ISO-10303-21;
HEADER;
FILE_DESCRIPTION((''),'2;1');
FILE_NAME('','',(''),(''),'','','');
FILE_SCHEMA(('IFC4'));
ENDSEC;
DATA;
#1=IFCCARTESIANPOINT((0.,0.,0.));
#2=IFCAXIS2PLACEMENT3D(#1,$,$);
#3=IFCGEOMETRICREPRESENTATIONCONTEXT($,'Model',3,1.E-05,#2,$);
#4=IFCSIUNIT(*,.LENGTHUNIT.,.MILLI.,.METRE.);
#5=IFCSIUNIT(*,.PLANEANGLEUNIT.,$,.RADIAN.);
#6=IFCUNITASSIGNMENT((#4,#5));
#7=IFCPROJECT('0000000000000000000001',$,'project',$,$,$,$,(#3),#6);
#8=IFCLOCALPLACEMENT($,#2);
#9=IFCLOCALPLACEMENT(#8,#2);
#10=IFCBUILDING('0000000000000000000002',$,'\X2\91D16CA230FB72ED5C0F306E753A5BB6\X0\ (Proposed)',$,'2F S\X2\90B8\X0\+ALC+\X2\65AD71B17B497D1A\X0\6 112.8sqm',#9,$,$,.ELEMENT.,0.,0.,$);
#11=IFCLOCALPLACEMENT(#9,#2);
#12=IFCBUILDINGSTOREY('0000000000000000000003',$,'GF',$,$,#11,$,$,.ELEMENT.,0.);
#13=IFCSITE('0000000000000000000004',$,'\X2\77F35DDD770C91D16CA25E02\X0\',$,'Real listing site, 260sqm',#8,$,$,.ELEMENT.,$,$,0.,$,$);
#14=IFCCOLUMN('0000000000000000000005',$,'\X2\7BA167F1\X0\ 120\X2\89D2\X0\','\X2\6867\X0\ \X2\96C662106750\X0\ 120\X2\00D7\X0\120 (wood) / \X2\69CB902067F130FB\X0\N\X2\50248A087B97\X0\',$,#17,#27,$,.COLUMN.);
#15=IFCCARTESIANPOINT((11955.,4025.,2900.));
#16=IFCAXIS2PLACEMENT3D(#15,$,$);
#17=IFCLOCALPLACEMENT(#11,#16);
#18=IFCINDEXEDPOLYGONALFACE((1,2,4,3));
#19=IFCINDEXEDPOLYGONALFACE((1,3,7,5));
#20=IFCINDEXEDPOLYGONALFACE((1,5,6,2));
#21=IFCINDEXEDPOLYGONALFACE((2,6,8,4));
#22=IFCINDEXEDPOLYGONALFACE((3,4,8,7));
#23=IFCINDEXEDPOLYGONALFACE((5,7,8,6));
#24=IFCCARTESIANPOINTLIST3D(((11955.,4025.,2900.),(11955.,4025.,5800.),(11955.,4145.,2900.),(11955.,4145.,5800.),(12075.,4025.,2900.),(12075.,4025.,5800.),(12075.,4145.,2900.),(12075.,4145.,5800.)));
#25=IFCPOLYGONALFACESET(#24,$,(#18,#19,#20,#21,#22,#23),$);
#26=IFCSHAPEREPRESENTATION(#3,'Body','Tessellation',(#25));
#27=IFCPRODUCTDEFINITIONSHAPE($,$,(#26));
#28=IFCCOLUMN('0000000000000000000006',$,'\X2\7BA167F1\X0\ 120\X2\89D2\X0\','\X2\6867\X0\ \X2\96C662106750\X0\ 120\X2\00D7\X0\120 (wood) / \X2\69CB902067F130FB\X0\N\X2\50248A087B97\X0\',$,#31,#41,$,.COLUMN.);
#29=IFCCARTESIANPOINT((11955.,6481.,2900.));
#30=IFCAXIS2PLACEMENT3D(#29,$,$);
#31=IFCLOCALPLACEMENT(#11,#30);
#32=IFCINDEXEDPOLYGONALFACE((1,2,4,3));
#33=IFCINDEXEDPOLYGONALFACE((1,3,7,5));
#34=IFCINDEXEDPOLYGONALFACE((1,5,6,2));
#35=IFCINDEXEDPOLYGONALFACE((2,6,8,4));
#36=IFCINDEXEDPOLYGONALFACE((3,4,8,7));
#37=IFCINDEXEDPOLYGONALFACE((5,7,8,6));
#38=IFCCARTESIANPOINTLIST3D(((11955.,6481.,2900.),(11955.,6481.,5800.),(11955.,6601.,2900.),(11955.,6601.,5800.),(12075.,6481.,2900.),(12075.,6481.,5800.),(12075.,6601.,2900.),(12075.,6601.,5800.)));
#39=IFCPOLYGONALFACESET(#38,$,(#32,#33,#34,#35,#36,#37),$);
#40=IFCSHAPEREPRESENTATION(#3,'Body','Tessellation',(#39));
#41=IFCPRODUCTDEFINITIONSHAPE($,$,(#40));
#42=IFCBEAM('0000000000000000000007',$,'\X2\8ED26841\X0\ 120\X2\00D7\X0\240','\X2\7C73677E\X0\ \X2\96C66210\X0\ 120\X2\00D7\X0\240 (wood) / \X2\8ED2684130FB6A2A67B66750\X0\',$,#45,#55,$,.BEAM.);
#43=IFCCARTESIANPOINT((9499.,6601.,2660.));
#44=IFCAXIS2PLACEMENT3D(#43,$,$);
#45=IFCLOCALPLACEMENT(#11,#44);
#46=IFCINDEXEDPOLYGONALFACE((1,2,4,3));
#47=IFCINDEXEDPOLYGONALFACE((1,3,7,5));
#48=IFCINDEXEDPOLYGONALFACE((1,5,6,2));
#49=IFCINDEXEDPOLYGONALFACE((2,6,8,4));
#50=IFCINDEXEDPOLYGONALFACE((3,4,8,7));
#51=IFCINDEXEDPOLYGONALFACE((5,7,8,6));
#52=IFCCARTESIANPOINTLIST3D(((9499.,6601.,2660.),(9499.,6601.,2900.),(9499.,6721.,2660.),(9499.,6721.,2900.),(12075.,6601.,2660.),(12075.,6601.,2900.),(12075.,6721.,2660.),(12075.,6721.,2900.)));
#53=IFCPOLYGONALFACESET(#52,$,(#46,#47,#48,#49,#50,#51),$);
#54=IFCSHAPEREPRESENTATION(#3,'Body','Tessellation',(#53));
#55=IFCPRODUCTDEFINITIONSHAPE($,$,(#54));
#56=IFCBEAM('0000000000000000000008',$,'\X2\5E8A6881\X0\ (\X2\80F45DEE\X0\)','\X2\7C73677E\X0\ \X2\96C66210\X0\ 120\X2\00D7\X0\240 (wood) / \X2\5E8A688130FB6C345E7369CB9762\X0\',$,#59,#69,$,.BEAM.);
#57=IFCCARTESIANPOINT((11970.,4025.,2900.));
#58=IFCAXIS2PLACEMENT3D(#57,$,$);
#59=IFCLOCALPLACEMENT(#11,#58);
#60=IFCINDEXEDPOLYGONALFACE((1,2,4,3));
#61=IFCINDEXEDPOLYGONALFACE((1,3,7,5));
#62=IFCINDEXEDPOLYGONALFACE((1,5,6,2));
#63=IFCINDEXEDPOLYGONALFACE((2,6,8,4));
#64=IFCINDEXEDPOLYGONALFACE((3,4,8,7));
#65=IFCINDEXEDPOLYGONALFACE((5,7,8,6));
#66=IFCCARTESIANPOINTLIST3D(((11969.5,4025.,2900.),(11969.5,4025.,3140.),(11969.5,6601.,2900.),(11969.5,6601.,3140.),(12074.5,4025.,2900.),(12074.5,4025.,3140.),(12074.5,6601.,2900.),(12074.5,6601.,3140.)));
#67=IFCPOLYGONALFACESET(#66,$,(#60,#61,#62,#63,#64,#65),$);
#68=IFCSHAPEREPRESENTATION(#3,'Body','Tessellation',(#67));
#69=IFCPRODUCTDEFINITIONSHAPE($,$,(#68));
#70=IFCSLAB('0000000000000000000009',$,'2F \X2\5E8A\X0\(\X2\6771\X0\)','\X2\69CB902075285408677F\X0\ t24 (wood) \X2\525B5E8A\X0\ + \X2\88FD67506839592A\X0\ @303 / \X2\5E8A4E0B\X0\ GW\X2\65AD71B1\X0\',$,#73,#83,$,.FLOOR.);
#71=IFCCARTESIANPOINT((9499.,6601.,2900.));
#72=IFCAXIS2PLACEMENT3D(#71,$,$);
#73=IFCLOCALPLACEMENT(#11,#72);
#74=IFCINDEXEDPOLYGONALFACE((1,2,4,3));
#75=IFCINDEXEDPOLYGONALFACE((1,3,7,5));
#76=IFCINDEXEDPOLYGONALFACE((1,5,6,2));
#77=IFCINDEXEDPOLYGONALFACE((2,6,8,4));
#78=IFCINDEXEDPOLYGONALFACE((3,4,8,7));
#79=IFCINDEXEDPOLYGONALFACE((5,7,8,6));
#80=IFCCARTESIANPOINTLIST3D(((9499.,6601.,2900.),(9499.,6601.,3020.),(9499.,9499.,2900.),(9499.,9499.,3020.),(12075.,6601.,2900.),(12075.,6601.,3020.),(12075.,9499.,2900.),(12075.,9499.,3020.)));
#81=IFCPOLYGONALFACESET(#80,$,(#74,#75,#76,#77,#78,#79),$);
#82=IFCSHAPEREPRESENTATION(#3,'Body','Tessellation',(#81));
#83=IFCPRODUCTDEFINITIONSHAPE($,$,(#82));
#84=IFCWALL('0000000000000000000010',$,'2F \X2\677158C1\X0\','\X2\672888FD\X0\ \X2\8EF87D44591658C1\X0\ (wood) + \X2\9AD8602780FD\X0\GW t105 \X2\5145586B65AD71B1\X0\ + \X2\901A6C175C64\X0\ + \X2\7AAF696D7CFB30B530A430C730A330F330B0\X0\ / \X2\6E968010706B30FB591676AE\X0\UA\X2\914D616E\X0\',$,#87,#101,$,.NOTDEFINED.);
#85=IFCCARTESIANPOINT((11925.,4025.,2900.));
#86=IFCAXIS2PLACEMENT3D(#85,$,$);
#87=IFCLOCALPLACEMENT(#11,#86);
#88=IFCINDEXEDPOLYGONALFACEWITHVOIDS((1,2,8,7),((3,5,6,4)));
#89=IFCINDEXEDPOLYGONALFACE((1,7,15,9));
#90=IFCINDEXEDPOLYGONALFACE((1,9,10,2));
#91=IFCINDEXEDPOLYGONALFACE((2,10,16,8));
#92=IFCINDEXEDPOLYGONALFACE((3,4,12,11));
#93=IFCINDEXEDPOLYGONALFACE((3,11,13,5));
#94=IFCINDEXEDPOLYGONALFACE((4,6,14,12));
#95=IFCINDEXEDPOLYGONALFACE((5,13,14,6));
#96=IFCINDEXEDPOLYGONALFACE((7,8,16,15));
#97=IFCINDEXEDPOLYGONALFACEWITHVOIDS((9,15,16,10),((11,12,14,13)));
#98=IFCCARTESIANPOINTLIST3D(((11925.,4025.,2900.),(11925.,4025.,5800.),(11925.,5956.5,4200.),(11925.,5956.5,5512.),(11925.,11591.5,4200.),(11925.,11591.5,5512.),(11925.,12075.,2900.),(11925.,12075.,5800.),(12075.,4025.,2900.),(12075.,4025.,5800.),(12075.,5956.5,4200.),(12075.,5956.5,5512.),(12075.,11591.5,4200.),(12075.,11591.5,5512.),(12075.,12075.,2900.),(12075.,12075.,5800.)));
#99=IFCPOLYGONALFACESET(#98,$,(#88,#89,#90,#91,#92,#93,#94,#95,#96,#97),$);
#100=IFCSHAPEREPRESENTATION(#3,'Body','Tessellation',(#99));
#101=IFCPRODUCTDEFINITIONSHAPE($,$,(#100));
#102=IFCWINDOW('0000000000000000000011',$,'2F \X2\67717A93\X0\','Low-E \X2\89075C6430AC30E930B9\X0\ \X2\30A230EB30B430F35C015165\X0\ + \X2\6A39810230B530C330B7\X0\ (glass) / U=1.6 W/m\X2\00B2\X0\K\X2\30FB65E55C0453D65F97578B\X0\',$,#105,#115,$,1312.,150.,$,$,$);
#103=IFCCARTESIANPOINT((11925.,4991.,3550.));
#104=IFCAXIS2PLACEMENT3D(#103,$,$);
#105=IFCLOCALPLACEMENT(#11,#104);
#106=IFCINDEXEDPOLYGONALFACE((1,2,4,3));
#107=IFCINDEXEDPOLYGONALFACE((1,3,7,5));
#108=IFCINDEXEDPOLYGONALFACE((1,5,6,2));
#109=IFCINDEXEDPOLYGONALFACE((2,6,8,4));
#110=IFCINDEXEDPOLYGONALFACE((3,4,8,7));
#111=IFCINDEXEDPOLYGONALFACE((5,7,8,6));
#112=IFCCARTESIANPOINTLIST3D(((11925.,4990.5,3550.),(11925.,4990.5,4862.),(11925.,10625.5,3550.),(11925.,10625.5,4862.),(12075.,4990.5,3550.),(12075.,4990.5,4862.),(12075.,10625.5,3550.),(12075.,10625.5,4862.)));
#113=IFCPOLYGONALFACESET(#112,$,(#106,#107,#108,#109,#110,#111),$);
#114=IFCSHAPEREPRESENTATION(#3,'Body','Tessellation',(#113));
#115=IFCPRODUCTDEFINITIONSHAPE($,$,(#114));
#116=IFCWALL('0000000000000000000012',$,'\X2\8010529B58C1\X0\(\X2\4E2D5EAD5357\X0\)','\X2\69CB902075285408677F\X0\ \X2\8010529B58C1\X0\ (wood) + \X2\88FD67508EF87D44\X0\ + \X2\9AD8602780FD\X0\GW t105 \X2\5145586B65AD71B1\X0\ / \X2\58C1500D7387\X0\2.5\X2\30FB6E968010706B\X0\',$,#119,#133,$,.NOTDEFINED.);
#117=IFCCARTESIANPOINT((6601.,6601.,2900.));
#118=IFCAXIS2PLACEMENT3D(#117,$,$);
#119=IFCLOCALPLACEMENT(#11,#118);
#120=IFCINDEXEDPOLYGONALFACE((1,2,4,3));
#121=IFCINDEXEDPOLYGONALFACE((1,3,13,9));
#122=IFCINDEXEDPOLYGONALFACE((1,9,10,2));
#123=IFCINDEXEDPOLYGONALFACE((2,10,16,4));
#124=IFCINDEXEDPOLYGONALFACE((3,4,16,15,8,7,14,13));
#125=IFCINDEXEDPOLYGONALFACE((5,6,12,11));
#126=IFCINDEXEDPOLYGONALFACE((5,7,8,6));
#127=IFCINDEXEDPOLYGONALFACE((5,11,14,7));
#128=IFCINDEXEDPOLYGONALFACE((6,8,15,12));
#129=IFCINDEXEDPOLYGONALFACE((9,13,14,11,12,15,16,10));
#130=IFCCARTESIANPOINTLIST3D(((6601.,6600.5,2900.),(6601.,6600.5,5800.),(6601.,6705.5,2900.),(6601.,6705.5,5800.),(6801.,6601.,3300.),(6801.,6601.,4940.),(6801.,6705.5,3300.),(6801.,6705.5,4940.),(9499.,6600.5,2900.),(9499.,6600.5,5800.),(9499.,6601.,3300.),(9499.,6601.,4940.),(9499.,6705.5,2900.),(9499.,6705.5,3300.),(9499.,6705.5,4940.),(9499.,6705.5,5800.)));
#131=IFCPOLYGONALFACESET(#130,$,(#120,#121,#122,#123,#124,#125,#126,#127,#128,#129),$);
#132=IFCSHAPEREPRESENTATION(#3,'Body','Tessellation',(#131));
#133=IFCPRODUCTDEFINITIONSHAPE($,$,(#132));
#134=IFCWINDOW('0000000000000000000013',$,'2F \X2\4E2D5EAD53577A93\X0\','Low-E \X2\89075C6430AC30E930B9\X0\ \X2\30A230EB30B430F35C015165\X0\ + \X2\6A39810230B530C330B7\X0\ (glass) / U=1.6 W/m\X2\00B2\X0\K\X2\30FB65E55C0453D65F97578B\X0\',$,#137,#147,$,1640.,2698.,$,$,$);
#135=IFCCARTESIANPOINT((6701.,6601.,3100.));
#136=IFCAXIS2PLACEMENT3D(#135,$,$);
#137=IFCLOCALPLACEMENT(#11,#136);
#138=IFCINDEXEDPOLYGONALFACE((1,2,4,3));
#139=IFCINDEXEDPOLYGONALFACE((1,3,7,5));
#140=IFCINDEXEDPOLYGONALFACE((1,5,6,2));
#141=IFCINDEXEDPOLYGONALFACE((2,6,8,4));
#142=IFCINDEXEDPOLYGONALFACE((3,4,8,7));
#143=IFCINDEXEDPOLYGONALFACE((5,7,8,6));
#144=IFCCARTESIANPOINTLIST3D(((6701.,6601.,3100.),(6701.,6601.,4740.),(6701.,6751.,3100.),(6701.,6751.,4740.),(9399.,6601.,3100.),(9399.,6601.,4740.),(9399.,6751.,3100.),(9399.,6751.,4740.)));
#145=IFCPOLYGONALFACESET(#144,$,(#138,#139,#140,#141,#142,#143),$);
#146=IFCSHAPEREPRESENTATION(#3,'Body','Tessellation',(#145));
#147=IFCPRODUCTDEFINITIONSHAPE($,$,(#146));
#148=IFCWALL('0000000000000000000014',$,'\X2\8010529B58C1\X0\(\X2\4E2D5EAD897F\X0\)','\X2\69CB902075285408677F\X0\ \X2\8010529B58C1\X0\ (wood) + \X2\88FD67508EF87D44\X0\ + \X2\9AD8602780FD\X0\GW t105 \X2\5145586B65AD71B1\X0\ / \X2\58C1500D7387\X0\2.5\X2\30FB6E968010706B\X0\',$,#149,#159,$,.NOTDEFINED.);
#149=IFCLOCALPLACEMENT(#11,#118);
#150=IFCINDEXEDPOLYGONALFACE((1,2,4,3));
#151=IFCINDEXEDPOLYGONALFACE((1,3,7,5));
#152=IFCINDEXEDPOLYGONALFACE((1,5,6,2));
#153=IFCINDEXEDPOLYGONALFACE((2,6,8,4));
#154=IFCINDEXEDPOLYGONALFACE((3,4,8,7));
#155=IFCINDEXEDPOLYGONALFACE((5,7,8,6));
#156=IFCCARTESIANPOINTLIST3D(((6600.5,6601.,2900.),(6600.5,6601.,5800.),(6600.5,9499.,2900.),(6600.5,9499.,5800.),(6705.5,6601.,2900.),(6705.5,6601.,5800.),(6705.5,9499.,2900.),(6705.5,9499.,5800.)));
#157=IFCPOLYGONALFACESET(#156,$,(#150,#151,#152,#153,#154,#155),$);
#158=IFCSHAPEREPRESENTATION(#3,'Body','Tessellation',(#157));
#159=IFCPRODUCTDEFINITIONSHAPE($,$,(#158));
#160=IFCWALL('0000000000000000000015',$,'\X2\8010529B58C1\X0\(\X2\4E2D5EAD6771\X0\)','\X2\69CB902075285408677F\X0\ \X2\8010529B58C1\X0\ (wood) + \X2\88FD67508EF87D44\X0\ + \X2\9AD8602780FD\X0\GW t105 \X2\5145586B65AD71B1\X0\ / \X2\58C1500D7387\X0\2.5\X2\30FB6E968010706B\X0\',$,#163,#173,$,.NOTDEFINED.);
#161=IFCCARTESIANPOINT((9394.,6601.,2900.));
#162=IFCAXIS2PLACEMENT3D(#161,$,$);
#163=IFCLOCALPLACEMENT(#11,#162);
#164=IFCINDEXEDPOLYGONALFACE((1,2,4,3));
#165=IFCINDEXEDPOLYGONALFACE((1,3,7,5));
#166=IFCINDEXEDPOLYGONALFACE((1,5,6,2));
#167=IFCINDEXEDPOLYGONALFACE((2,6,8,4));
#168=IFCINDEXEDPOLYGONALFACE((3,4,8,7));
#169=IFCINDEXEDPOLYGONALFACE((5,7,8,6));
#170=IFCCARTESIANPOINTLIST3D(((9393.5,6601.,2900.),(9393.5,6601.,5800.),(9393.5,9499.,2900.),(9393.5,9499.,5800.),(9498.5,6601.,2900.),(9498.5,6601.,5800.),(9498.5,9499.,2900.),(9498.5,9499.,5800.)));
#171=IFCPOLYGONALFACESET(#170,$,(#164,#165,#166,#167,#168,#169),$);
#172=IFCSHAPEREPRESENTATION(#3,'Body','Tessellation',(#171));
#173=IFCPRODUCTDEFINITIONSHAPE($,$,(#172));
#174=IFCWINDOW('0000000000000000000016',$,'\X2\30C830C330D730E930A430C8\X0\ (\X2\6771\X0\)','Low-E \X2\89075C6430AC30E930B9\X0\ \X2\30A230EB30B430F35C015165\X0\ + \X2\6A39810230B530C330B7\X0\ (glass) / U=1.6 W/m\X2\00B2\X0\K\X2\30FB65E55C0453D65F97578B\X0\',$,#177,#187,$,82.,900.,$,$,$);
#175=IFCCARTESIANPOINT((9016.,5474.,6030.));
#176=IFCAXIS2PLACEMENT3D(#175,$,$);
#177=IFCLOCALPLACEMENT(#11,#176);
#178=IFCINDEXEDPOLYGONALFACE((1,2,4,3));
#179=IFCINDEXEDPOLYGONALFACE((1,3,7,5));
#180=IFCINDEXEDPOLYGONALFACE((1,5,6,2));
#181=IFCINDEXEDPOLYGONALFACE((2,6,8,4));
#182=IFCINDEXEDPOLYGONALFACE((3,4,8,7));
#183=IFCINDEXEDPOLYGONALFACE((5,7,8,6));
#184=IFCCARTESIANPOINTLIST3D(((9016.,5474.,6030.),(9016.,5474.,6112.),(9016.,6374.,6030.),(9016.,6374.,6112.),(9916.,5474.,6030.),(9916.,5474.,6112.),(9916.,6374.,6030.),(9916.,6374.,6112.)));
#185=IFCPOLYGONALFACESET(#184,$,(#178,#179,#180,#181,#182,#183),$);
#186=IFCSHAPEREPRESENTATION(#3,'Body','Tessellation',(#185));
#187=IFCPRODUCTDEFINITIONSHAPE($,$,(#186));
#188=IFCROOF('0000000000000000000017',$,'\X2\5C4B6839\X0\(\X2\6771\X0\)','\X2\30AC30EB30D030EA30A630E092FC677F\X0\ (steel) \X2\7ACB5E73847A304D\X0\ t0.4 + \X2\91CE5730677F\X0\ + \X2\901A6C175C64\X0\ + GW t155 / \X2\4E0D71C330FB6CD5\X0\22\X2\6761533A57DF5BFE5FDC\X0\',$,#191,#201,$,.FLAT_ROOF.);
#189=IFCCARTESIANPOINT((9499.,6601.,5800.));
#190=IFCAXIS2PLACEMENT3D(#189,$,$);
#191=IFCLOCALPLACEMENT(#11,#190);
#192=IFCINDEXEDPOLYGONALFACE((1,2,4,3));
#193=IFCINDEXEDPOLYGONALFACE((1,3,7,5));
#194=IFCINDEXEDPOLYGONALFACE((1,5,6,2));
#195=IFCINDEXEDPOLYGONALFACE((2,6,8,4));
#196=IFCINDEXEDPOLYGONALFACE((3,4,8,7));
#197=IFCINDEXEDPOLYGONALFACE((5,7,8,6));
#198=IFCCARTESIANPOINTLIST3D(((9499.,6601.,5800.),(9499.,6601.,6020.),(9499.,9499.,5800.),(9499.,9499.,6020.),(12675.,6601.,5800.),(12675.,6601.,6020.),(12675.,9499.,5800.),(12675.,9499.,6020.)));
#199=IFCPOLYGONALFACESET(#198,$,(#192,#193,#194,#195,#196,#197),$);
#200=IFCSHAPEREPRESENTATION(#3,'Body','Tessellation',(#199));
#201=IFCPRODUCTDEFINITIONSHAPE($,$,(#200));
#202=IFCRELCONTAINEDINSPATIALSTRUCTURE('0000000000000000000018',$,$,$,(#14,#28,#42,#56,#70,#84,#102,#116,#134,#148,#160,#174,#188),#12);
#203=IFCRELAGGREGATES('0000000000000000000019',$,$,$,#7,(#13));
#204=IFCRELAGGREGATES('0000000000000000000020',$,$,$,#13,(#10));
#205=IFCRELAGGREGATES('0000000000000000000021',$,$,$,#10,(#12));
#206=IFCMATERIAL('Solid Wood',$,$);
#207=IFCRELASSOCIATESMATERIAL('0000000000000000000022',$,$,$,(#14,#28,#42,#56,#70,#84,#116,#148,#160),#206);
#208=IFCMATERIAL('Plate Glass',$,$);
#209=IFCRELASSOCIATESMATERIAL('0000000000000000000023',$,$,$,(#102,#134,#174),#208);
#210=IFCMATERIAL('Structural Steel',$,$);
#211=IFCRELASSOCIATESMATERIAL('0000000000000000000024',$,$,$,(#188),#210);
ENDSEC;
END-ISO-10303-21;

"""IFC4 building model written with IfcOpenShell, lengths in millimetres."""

from ifc_helpers import new_model, si_unit, frame, frame_2d, origin, place, context, project, spatial, rectangle, extrude, material, element, fill, save


model = new_model("IFC4")

# Units and contexts
model_context = context("Model", 3, precision=1e-05, world=origin())
ifc_project = project(units=[si_unit("LENGTHUNIT", "METRE", prefix="MILLI"), si_unit("PLANEANGLEUNIT", "RADIAN")], contexts=[model_context])

# Site, building, storey
site_placement = place(None, origin())
site = spatial("IfcSite", under=ifc_project, at=site_placement, Name="石川県金沢市", ObjectType="Real listing site, 260sqm", CompositionType="ELEMENT", RefElevation=0.0)
building_placement = place(site_placement, origin())
building = spatial("IfcBuilding", under=site, at=building_placement, Name="金沢・狭小の町家 (Proposed)", ObjectType="2F S邸+ALC+断熱等級6 112.8sqm", CompositionType="ELEMENT", ElevationOfRefHeight=0.0, ElevationOfTerrain=0.0)
storey_placement = place(building_placement, origin())
storey = spatial("IfcBuildingStorey", under=building, at=storey_placement, Name="GF", CompositionType="ELEMENT", Elevation=0.0)

# Columns
ifc_material_1 = material(Name="Solid Wood")
column_1_placement = place(storey_placement, frame((11955.0, 4025.0, 2900.0)))
element("IfcColumn", 1, at=column_1_placement, inside=storey, material=ifc_material_1, Name="管柱 120角", Description="桧 集成材 120×120 (wood) / 構造柱・N値計算", PredefinedType="COLUMN", context=model_context, shape_type="SweptSolid", body=[
    extrude(rectangle(XDim=120.0, YDim=120.0, at=frame_2d((60.0, 60.0))), frame((11955.0, 4025.0, 2900.0)), (0.0, 0.0, 1.0), 2900.0),
])
column_2_placement = place(storey_placement, frame((11955.0, 6481.0, 2900.0)))
element("IfcColumn", 2, at=column_2_placement, inside=storey, material=ifc_material_1, Name="管柱 120角", Description="桧 集成材 120×120 (wood) / 構造柱・N値計算", PredefinedType="COLUMN", context=model_context, shape_type="SweptSolid", body=[
    extrude(rectangle(XDim=120.0, YDim=120.0, at=frame_2d((60.0, 60.0))), frame((11955.0, 6481.0, 2900.0)), (0.0, 0.0, 1.0), 2900.0),
])

# Beams
beam_1_placement = place(storey_placement, frame((9499.0, 6601.0, 2660.0)))
element("IfcBeam", 3, at=beam_1_placement, inside=storey, material=ifc_material_1, Name="軒桁 120×240", Description="米松 集成 120×240 (wood) / 軒桁・横架材", PredefinedType="BEAM", context=model_context, shape_type="SweptSolid", body=[
    extrude(rectangle(XDim=2576.0, YDim=120.0, at=frame_2d((1288.0, 60.0))), frame((9499.0, 6601.0, 2660.0)), (0.0, 0.0, 1.0), 240.0),
])
beam_2_placement = place(storey_placement, frame((11970.0, 4025.0, 2900.0)))
element("IfcBeam", 4, at=beam_2_placement, inside=storey, material=ifc_material_1, Name="床梁 (胴差)", Description="米松 集成 120×240 (wood) / 床梁・水平構面", PredefinedType="BEAM", context=model_context, shape_type="SweptSolid", body=[
    extrude(rectangle(XDim=105.0, YDim=2576.0, at=frame_2d((52.0, 1288.0))), frame((11970.0, 4025.0, 2900.0)), (0.0, 0.0, 1.0), 240.0),
])

# Slab
slab_placement = place(storey_placement, frame((9499.0, 6601.0, 2900.0)))
element("IfcSlab", 5, at=slab_placement, inside=storey, material=ifc_material_1, Name="2F 床(東)", Description="構造用合板 t24 (wood) 剛床 + 製材根太 @303 / 床下 GW断熱", PredefinedType="FLOOR", context=model_context, shape_type="SweptSolid", body=[
    extrude(rectangle(XDim=2576.0, YDim=2898.0, at=frame_2d((1288.0, 1449.0))), frame((9499.0, 6601.0, 2900.0)), (0.0, 0.0, 1.0), 120.0),
])

# Walls, openings, windows
wall_1_placement = place(storey_placement, frame((11925.0, 4025.0, 2900.0)))
wall_1 = element("IfcWall", 6, at=wall_1_placement, inside=storey, material=ifc_material_1, Name="2F 東壁", Description="木製 軸組外壁 (wood) + 高性能GW t105 充填断熱 + 通気層 + 窯業系サイディング / 準耐火・外皮UA配慮", PredefinedType="NOTDEFINED", context=model_context, shape_type="SweptSolid", body=[
    extrude(rectangle(XDim=150.0, YDim=8050.0, at=frame_2d((75.0, 4025.0))), frame((11925.0, 4025.0, 2900.0)), (0.0, 0.0, 1.0), 2900.0),
])
opening_1_placement = place(storey_placement, frame((11925.0, 4991.0, 3550.0)))
opening_1 = element("IfcOpeningElement", 7, at=opening_1_placement, cuts=wall_1, PredefinedType="NOTDEFINED", context=model_context, shape_type="SweptSolid", body=[
    extrude(rectangle(XDim=150.0, YDim=5635.0, at=frame_2d((75.0, 2817.0))), frame((11925.0, 4991.0, 3550.0)), (0.0, 0.0, 1.0), 1312.0),
])
ifc_material_2 = material(Name="Plate Glass")
window_1_placement = place(storey_placement, frame((11925.0, 4991.0, 3550.0)))
window_1 = element("IfcWindow", 8, at=window_1_placement, inside=storey, material=ifc_material_2, Name="2F 東窓", Description="Low-E 複層ガラス アルゴン封入 + 樹脂サッシ (glass) / U=1.6 W/m²K・日射取得型", OverallHeight=1312.0, OverallWidth=150.0, context=model_context, shape_type="SweptSolid", body=[
    extrude(rectangle(XDim=150.0, YDim=5635.0, at=frame_2d((75.0, 2817.0))), frame((11925.0, 4991.0, 3550.0)), (0.0, 0.0, 1.0), 1312.0),
])
fill(opening_1, window_1)
wall_2_placement = place(storey_placement, frame((6601.0, 6601.0, 2900.0)))
wall_2 = element("IfcWall", 9, at=wall_2_placement, inside=storey, material=ifc_material_1, Name="耐力壁(中庭南)", Description="構造用合板 耐力壁 (wood) + 製材軸組 + 高性能GW t105 充填断熱 / 壁倍率2.5・準耐火", PredefinedType="NOTDEFINED", context=model_context, shape_type="SweptSolid", body=[
    extrude(rectangle(XDim=2898.0, YDim=105.0, at=frame_2d((1449.0, 52.0))), frame((6601.0, 6601.0, 2900.0)), (0.0, 0.0, 1.0), 2900.0),
])
opening_2_placement = place(storey_placement, frame((6701.0, 6601.0, 3100.0)))
opening_2 = element("IfcOpeningElement", 10, at=opening_2_placement, cuts=wall_2, PredefinedType="NOTDEFINED", context=model_context, shape_type="SweptSolid", body=[
    extrude(rectangle(XDim=2698.0, YDim=150.0, at=frame_2d((1349.0, 75.0))), frame((6701.0, 6601.0, 3100.0)), (0.0, 0.0, 1.0), 1640.0),
])
window_2_placement = place(storey_placement, frame((6701.0, 6601.0, 3100.0)))
window_2 = element("IfcWindow", 11, at=window_2_placement, inside=storey, material=ifc_material_2, Name="2F 中庭南窓", Description="Low-E 複層ガラス アルゴン封入 + 樹脂サッシ (glass) / U=1.6 W/m²K・日射取得型", OverallHeight=1640.0, OverallWidth=2698.0, context=model_context, shape_type="SweptSolid", body=[
    extrude(rectangle(XDim=2698.0, YDim=150.0, at=frame_2d((1349.0, 75.0))), frame((6701.0, 6601.0, 3100.0)), (0.0, 0.0, 1.0), 1640.0),
])
fill(opening_2, window_2)

# Walls
wall_3_placement = place(storey_placement, frame((6601.0, 6601.0, 2900.0)))
element("IfcWall", 12, at=wall_3_placement, inside=storey, material=ifc_material_1, Name="耐力壁(中庭西)", Description="構造用合板 耐力壁 (wood) + 製材軸組 + 高性能GW t105 充填断熱 / 壁倍率2.5・準耐火", PredefinedType="NOTDEFINED", context=model_context, shape_type="SweptSolid", body=[
    extrude(rectangle(XDim=105.0, YDim=2898.0, at=frame_2d((52.0, 1449.0))), frame((6601.0, 6601.0, 2900.0)), (0.0, 0.0, 1.0), 2900.0),
])
wall_4_placement = place(storey_placement, frame((9394.0, 6601.0, 2900.0)))
element("IfcWall", 13, at=wall_4_placement, inside=storey, material=ifc_material_1, Name="耐力壁(中庭東)", Description="構造用合板 耐力壁 (wood) + 製材軸組 + 高性能GW t105 充填断熱 / 壁倍率2.5・準耐火", PredefinedType="NOTDEFINED", context=model_context, shape_type="SweptSolid", body=[
    extrude(rectangle(XDim=105.0, YDim=2898.0, at=frame_2d((52.0, 1449.0))), frame((9394.0, 6601.0, 2900.0)), (0.0, 0.0, 1.0), 2900.0),
])

# Window
window_3_placement = place(storey_placement, frame((9016.0, 5474.0, 6030.0)))
element("IfcWindow", 14, at=window_3_placement, inside=storey, material=ifc_material_2, Name="トップライト (東)", Description="Low-E 複層ガラス アルゴン封入 + 樹脂サッシ (glass) / U=1.6 W/m²K・日射取得型", OverallHeight=82.0, OverallWidth=900.0, context=model_context, shape_type="SweptSolid", body=[
    extrude(rectangle(XDim=900.0, YDim=900.0, at=frame_2d((450.0, 450.0))), frame((9016.0, 5474.0, 6030.0)), (0.0, 0.0, 1.0), 82.0),
])

# Roof
ifc_material_3 = material(Name="Structural Steel")
for number, where, name in (
    (15, (9499.0, 6601.0, 5800.0), "屋根(東)"),
):
    element("IfcRoof", number, at=place(storey_placement, frame(where)), inside=storey, material=ifc_material_3, Name=name, Description="ガルバリウム鋼板 (steel) 立平葺き t0.4 + 野地板 + 通気層 + GW t155 / 不燃・法22条区域対応", PredefinedType="FLAT_ROOF", context=model_context, shape_type="SweptSolid", body=[
        extrude(rectangle(XDim=3176.0, YDim=2898.0, at=frame_2d((1588.0, 1449.0))), frame((9499.0, 6601.0, 5800.0)), (0.0, 0.0, 1.0), 220.0),
    ])

save(model, "model.ifc")
